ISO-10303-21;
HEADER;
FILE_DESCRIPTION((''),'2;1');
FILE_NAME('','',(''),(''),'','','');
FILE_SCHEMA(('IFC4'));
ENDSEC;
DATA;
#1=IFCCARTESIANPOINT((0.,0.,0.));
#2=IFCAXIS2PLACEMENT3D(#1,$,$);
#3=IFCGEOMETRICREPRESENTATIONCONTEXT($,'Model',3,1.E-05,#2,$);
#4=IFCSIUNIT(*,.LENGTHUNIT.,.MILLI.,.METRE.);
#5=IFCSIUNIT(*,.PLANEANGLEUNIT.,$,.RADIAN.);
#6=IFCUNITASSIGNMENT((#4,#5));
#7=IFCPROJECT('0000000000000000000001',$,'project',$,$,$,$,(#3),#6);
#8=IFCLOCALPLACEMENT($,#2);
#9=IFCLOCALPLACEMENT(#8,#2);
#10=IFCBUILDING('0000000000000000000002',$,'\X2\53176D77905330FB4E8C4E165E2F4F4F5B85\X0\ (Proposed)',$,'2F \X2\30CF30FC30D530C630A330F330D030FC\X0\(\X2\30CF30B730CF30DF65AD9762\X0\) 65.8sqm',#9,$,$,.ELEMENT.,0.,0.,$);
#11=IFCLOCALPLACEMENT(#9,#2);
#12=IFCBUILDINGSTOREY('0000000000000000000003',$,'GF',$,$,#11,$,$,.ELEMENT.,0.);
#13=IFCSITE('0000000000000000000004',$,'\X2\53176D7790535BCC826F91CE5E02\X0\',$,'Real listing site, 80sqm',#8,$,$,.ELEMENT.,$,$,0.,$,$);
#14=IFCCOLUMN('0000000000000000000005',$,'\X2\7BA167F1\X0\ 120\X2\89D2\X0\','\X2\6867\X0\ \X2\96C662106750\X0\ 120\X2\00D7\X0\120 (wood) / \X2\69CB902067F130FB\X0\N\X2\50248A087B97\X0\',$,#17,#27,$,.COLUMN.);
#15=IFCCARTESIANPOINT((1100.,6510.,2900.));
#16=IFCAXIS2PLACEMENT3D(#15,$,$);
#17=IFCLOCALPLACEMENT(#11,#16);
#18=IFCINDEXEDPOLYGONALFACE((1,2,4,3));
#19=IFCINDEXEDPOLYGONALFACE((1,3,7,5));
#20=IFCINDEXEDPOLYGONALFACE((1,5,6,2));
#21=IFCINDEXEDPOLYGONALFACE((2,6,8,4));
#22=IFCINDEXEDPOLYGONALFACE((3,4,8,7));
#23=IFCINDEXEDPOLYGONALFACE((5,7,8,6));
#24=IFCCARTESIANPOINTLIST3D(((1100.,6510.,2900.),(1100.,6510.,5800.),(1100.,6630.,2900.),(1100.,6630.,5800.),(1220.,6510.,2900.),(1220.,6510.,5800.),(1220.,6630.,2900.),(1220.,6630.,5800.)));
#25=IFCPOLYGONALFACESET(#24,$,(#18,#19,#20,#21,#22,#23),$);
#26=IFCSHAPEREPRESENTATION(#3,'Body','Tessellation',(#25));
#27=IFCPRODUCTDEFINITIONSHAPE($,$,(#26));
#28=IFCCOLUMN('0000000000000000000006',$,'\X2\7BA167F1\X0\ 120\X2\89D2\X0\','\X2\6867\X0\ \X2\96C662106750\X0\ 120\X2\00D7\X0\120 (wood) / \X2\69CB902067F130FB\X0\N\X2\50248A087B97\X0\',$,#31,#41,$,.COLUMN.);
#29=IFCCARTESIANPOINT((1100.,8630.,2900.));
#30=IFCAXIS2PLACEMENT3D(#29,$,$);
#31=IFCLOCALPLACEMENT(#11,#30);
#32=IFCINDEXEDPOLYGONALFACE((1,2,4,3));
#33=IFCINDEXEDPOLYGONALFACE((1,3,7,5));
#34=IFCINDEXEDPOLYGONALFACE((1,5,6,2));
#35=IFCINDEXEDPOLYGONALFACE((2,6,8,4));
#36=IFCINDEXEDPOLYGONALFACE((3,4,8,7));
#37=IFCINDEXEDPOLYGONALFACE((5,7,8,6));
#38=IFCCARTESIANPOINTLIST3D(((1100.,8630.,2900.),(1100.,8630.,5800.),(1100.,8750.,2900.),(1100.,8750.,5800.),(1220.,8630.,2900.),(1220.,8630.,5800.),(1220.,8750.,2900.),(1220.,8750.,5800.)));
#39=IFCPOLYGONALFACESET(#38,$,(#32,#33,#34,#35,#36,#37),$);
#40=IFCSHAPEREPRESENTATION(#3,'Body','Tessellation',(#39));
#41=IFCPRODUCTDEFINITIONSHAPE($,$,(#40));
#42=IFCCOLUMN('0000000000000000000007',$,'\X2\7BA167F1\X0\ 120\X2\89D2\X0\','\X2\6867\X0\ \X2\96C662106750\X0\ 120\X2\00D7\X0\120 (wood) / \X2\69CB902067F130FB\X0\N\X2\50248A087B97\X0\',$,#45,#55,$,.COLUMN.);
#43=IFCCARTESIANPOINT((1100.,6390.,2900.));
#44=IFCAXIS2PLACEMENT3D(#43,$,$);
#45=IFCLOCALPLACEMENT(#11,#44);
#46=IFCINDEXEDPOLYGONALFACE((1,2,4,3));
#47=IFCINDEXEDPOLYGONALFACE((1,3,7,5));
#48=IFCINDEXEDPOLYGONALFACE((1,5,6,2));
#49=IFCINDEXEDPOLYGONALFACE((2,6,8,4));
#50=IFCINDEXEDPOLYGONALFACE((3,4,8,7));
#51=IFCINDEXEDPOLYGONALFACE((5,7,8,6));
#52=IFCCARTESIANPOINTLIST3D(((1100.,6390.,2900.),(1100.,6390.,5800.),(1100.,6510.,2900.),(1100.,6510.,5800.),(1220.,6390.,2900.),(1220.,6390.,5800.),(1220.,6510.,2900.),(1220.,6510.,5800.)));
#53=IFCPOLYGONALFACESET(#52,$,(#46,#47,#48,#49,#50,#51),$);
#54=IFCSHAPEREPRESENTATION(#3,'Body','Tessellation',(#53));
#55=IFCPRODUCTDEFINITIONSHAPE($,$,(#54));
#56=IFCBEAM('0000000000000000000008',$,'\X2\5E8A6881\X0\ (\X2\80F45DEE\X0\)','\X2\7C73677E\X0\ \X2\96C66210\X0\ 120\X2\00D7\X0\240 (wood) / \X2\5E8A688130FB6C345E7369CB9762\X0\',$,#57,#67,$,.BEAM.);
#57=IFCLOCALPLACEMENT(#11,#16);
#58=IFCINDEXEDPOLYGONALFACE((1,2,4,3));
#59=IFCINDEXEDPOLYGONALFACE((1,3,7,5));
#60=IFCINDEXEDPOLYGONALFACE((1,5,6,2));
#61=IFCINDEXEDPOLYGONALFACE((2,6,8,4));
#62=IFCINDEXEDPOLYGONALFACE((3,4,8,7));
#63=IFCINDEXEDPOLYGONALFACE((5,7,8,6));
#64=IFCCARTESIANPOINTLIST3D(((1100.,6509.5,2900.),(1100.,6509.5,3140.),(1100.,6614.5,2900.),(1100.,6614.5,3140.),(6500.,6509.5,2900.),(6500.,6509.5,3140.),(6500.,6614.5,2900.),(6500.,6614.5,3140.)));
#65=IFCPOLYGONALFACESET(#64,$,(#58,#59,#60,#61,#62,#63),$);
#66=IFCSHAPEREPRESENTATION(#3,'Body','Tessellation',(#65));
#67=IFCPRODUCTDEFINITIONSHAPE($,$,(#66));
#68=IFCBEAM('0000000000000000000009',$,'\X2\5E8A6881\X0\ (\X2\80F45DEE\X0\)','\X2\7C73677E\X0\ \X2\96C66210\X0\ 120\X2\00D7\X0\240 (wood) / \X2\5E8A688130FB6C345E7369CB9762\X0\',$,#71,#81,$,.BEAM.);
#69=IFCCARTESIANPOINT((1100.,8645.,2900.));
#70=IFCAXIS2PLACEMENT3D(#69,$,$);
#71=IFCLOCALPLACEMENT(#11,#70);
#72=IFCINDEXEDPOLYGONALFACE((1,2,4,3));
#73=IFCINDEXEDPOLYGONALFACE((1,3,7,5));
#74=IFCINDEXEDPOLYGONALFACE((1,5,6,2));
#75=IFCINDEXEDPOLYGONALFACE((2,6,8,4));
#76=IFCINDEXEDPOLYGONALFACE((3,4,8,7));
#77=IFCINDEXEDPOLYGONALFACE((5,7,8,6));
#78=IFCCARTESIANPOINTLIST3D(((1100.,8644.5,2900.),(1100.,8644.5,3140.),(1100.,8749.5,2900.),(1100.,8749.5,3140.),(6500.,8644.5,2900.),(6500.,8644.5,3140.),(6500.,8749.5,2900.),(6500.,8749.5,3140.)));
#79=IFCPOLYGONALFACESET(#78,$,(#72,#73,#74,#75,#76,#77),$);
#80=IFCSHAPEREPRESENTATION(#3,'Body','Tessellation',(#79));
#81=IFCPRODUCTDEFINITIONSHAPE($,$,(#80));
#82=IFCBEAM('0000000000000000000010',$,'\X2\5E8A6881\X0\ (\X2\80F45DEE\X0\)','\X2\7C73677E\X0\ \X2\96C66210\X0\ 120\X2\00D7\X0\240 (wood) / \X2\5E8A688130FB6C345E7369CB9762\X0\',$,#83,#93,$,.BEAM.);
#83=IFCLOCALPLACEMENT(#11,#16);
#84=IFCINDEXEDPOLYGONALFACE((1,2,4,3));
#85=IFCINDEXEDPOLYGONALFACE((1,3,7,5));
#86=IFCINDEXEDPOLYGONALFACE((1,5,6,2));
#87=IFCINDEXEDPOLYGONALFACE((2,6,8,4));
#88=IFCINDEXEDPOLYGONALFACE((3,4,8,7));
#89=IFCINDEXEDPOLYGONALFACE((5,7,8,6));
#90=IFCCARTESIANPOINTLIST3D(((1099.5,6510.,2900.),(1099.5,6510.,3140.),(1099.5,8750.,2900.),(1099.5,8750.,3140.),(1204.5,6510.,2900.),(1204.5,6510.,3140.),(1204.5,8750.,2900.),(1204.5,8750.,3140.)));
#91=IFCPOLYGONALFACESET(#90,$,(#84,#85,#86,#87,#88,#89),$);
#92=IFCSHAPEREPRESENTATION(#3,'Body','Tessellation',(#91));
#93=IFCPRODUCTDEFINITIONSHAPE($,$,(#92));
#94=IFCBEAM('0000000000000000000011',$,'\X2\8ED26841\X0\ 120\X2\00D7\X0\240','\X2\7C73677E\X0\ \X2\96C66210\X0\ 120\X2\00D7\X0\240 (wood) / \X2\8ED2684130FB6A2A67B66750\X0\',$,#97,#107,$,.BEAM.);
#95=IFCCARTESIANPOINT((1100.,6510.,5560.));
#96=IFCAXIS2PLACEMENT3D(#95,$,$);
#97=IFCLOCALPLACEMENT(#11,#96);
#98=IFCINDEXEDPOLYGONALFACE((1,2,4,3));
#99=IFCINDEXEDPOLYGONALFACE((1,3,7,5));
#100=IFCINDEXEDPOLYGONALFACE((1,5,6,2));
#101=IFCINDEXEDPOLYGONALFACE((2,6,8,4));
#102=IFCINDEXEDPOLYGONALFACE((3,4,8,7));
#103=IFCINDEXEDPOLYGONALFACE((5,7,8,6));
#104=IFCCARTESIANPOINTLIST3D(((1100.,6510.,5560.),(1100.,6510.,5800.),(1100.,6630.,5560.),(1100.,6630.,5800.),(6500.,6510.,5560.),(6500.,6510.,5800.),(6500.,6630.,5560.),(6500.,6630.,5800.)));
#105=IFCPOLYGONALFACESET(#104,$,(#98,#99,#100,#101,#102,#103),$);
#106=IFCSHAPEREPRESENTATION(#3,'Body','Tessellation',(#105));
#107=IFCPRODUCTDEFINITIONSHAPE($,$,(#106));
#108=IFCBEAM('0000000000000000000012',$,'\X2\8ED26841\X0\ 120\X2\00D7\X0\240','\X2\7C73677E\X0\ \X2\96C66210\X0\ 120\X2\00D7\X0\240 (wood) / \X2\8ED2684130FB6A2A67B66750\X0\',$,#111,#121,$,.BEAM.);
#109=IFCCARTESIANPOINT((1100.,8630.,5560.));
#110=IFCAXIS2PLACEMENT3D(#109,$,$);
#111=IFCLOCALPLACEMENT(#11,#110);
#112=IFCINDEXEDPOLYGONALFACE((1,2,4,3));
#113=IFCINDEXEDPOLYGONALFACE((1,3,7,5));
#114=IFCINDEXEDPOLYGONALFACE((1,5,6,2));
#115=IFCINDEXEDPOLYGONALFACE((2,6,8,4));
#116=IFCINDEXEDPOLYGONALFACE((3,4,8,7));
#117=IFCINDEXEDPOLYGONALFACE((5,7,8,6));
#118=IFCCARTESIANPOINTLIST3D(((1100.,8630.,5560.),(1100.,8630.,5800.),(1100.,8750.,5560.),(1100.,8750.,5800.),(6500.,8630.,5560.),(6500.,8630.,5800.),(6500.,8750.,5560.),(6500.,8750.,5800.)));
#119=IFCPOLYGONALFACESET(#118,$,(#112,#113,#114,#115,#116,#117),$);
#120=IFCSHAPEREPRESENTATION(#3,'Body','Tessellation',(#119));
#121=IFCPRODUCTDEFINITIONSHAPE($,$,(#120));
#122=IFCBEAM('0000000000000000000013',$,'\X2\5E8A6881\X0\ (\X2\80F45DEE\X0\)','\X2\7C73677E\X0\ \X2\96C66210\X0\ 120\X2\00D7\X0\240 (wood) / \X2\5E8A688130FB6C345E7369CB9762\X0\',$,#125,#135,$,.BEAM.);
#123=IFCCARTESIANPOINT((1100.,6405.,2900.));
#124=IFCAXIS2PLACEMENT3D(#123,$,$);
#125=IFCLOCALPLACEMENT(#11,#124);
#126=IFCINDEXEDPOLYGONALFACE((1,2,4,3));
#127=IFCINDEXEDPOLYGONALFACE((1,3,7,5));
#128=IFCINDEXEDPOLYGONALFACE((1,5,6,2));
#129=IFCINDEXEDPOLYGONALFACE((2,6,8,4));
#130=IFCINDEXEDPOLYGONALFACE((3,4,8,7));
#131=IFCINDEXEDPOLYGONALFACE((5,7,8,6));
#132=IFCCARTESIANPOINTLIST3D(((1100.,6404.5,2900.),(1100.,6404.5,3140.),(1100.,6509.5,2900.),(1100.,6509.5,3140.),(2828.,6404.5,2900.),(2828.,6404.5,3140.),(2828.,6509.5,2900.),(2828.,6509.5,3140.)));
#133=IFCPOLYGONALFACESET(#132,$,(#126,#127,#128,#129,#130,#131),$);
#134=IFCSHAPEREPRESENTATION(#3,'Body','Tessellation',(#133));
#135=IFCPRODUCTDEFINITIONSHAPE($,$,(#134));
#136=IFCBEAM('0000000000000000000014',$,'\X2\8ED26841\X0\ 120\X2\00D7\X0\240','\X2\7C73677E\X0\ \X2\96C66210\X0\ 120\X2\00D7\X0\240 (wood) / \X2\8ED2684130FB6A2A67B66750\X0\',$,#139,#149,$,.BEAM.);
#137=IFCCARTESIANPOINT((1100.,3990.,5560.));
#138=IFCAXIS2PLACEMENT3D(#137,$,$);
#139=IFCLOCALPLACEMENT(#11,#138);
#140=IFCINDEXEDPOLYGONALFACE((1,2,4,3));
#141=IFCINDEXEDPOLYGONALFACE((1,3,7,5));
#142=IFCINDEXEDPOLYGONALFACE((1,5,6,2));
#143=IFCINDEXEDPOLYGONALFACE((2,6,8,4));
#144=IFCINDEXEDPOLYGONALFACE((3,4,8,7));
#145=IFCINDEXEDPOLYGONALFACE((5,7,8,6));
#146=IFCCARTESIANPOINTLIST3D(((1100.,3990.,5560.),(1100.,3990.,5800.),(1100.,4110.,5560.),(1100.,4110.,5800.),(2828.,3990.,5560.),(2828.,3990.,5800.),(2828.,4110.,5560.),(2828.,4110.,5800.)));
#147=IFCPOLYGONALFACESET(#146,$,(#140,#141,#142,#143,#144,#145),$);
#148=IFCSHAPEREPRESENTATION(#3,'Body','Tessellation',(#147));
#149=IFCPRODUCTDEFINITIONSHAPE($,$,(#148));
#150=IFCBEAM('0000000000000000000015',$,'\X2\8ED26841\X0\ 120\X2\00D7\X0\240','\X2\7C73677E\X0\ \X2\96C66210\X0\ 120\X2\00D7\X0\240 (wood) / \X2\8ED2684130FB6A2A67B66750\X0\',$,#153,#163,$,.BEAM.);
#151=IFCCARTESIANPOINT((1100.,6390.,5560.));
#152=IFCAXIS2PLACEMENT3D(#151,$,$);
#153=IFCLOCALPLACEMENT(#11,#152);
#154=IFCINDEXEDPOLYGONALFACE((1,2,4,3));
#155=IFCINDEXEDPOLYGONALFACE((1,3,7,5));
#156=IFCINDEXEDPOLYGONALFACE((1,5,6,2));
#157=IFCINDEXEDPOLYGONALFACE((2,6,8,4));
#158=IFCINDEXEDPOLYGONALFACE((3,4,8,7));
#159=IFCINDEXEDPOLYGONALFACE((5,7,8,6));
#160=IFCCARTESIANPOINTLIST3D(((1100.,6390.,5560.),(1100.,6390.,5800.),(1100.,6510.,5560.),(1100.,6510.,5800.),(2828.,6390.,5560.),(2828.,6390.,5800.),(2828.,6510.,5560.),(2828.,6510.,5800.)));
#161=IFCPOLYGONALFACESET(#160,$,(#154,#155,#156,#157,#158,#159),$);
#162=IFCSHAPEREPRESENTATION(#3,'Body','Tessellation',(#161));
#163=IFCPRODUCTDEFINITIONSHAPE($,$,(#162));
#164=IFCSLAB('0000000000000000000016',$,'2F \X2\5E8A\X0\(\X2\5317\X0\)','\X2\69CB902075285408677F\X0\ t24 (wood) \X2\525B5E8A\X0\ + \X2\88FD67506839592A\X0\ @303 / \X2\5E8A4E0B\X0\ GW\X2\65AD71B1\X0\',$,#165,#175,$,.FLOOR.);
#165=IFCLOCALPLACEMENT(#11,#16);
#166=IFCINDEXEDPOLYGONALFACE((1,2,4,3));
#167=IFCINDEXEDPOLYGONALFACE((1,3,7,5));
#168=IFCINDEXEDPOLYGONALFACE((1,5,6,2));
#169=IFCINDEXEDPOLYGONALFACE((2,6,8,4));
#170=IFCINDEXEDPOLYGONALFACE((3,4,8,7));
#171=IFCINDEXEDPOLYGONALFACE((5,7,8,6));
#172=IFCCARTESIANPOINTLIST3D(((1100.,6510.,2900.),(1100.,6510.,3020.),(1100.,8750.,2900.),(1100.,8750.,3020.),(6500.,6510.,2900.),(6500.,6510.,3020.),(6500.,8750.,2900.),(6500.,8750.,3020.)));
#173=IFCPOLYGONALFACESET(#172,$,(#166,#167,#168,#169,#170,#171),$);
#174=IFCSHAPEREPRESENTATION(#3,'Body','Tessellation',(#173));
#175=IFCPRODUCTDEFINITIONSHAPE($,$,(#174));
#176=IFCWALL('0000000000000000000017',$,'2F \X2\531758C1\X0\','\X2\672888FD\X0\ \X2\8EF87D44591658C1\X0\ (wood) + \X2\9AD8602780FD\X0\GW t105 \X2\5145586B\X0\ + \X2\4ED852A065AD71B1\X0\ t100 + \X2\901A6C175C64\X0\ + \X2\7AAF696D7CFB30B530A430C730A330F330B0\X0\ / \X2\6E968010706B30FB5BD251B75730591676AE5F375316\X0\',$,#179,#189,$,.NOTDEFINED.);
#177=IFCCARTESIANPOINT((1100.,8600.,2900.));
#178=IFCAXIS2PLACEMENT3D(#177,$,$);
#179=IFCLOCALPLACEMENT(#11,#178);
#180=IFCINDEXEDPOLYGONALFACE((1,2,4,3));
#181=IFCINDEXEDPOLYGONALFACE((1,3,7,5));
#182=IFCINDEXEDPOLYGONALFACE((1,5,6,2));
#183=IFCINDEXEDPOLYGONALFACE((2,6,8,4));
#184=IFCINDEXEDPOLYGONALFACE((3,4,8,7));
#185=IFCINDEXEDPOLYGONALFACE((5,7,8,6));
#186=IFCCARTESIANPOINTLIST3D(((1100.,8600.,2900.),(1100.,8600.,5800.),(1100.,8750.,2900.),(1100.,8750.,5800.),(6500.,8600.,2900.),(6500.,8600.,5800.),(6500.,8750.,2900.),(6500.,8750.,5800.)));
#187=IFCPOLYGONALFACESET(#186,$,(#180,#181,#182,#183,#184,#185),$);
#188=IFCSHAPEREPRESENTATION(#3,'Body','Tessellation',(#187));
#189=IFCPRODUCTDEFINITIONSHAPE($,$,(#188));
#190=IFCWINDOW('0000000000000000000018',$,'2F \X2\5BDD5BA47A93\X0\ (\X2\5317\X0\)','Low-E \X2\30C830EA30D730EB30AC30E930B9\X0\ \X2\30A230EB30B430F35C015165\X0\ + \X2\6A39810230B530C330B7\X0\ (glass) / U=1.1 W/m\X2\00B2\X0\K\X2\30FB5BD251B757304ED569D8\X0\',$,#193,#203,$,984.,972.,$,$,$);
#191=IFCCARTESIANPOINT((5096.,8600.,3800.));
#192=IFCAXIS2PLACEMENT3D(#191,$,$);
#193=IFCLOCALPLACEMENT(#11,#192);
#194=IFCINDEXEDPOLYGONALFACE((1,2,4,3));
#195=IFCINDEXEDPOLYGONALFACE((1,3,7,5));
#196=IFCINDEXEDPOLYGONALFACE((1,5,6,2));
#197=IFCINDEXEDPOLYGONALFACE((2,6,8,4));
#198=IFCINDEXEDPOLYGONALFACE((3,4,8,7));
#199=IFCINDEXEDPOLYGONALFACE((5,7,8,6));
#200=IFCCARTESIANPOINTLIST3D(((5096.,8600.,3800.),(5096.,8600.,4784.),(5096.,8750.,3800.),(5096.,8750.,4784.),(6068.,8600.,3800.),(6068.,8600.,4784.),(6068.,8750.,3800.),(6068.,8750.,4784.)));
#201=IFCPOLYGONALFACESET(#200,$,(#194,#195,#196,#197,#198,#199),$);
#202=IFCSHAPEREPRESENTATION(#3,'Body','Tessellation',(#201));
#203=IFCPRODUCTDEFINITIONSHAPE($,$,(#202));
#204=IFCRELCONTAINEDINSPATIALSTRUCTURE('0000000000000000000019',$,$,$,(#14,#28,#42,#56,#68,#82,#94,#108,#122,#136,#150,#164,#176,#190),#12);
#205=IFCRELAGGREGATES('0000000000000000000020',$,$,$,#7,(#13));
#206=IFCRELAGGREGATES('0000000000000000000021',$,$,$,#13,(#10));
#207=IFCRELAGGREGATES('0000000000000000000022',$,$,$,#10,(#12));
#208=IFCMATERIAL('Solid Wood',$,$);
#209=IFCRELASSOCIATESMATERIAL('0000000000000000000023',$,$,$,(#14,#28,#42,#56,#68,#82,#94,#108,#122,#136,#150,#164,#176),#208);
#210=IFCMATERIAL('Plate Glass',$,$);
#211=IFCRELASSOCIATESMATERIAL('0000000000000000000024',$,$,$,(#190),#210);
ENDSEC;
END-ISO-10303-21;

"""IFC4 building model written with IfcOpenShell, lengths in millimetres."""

from ifc_helpers import new_model, si_unit, frame, frame_2d, origin, place, context, project, spatial, rectangle, extrude, material, element, fill, save


model = new_model("IFC4")

# Units and contexts
model_context = context("Model", 3, precision=1e-05, world=origin())
ifc_project = project(units=[si_unit("LENGTHUNIT", "METRE", prefix="MILLI"), si_unit("PLANEANGLEUNIT", "RADIAN")], contexts=[model_context])

# Site, building, storey
site_placement = place(None, origin())
site = spatial("IfcSite", under=ifc_project, at=site_placement, Name="北海道富良野市", ObjectType="Real listing site, 80sqm", CompositionType="ELEMENT", RefElevation=0.0)
building_placement = place(site_placement, origin())
building = spatial("IfcBuilding", under=site, at=building_placement, Name="北海道・二世帯住宅 (Proposed)", ObjectType="2F ハーフティンバー(ハシハミ断面) 65.8sqm", CompositionType="ELEMENT", ElevationOfRefHeight=0.0, ElevationOfTerrain=0.0)
storey_placement = place(building_placement, origin())
storey = spatial("IfcBuildingStorey", under=building, at=storey_placement, Name="GF", CompositionType="ELEMENT", Elevation=0.0)

# Columns
ifc_material_1 = material(Name="Solid Wood")
column_1_placement = place(storey_placement, frame((1100.0, 6510.0, 2900.0)))
element("IfcColumn", 1, at=column_1_placement, inside=storey, material=ifc_material_1, Name="管柱 120角", Description="桧 集成材 120×120 (wood) / 構造柱・N値計算", PredefinedType="COLUMN", context=model_context, shape_type="SweptSolid", body=[
    extrude(rectangle(XDim=120.0, YDim=120.0, at=frame_2d((60.0, 60.0))), frame((1100.0, 6510.0, 2900.0)), (0.0, 0.0, 1.0), 2900.0),
])
column_2_placement = place(storey_placement, frame((1100.0, 8630.0, 2900.0)))
element("IfcColumn", 2, at=column_2_placement, inside=storey, material=ifc_material_1, Name="管柱 120角", Description="桧 集成材 120×120 (wood) / 構造柱・N値計算", PredefinedType="COLUMN", context=model_context, shape_type="SweptSolid", body=[
    extrude(rectangle(XDim=120.0, YDim=120.0, at=frame_2d((60.0, 60.0))), frame((1100.0, 8630.0, 2900.0)), (0.0, 0.0, 1.0), 2900.0),
])
column_3_placement = place(storey_placement, frame((1100.0, 6390.0, 2900.0)))
element("IfcColumn", 3, at=column_3_placement, inside=storey, material=ifc_material_1, Name="管柱 120角", Description="桧 集成材 120×120 (wood) / 構造柱・N値計算", PredefinedType="COLUMN", context=model_context, shape_type="SweptSolid", body=[
    extrude(rectangle(XDim=120.0, YDim=120.0, at=frame_2d((60.0, 60.0))), frame((1100.0, 6390.0, 2900.0)), (0.0, 0.0, 1.0), 2900.0),
])

# Beams
beam_1_placement = place(storey_placement, frame((1100.0, 6510.0, 2900.0)))
element("IfcBeam", 4, at=beam_1_placement, inside=storey, material=ifc_material_1, Name="床梁 (胴差)", Description="米松 集成 120×240 (wood) / 床梁・水平構面", PredefinedType="BEAM", context=model_context, shape_type="SweptSolid", body=[
    extrude(rectangle(XDim=5400.0, YDim=105.0, at=frame_2d((2700.0, 52.0))), frame((1100.0, 6510.0, 2900.0)), (0.0, 0.0, 1.0), 240.0),
])
beam_2_placement = place(storey_placement, frame((1100.0, 8645.0, 2900.0)))
element("IfcBeam", 5, at=beam_2_placement, inside=storey, material=ifc_material_1, Name="床梁 (胴差)", Description="米松 集成 120×240 (wood) / 床梁・水平構面", PredefinedType="BEAM", context=model_context, shape_type="SweptSolid", body=[
    extrude(rectangle(XDim=5400.0, YDim=105.0, at=frame_2d((2700.0, 52.0))), frame((1100.0, 8645.0, 2900.0)), (0.0, 0.0, 1.0), 240.0),
])
beam_3_placement = place(storey_placement, frame((1100.0, 6510.0, 2900.0)))
element("IfcBeam", 6, at=beam_3_placement, inside=storey, material=ifc_material_1, Name="床梁 (胴差)", Description="米松 集成 120×240 (wood) / 床梁・水平構面", PredefinedType="BEAM", context=model_context, shape_type="SweptSolid", body=[
    extrude(rectangle(XDim=105.0, YDim=2240.0, at=frame_2d((52.0, 1120.0))), frame((1100.0, 6510.0, 2900.0)), (0.0, 0.0, 1.0), 240.0),
])
beam_4_placement = place(storey_placement, frame((1100.0, 6510.0, 5560.0)))
element("IfcBeam", 7, at=beam_4_placement, inside=storey, material=ifc_material_1, Name="軒桁 120×240", Description="米松 集成 120×240 (wood) / 軒桁・横架材", PredefinedType="BEAM", context=model_context, shape_type="SweptSolid", body=[
    extrude(rectangle(XDim=5400.0, YDim=120.0, at=frame_2d((2700.0, 60.0))), frame((1100.0, 6510.0, 5560.0)), (0.0, 0.0, 1.0), 240.0),
])
beam_5_placement = place(storey_placement, frame((1100.0, 8630.0, 5560.0)))
element("IfcBeam", 8, at=beam_5_placement, inside=storey, material=ifc_material_1, Name="軒桁 120×240", Description="米松 集成 120×240 (wood) / 軒桁・横架材", PredefinedType="BEAM", context=model_context, shape_type="SweptSolid", body=[
    extrude(rectangle(XDim=5400.0, YDim=120.0, at=frame_2d((2700.0, 60.0))), frame((1100.0, 8630.0, 5560.0)), (0.0, 0.0, 1.0), 240.0),
])
beam_6_placement = place(storey_placement, frame((1100.0, 6405.0, 2900.0)))
element("IfcBeam", 9, at=beam_6_placement, inside=storey, material=ifc_material_1, Name="床梁 (胴差)", Description="米松 集成 120×240 (wood) / 床梁・水平構面", PredefinedType="BEAM", context=model_context, shape_type="SweptSolid", body=[
    extrude(rectangle(XDim=1728.0, YDim=105.0, at=frame_2d((864.0, 52.0))), frame((1100.0, 6405.0, 2900.0)), (0.0, 0.0, 1.0), 240.0),
])
beam_7_placement = place(storey_placement, frame((1100.0, 3990.0, 5560.0)))
element("IfcBeam", 10, at=beam_7_placement, inside=storey, material=ifc_material_1, Name="軒桁 120×240", Description="米松 集成 120×240 (wood) / 軒桁・横架材", PredefinedType="BEAM", context=model_context, shape_type="SweptSolid", body=[
    extrude(rectangle(XDim=1728.0, YDim=120.0, at=frame_2d((864.0, 60.0))), frame((1100.0, 3990.0, 5560.0)), (0.0, 0.0, 1.0), 240.0),
])
beam_8_placement = place(storey_placement, frame((1100.0, 6390.0, 5560.0)))
element("IfcBeam", 11, at=beam_8_placement, inside=storey, material=ifc_material_1, Name="軒桁 120×240", Description="米松 集成 120×240 (wood) / 軒桁・横架材", PredefinedType="BEAM", context=model_context, shape_type="SweptSolid", body=[
    extrude(rectangle(XDim=1728.0, YDim=120.0, at=frame_2d((864.0, 60.0))), frame((1100.0, 6390.0, 5560.0)), (0.0, 0.0, 1.0), 240.0),
])

# Slab
slab_placement = place(storey_placement, frame((1100.0, 6510.0, 2900.0)))
element("IfcSlab", 12, at=slab_placement, inside=storey, material=ifc_material_1, Name="2F 床(北)", Description="構造用合板 t24 (wood) 剛床 + 製材根太 @303 / 床下 GW断熱", PredefinedType="FLOOR", context=model_context, shape_type="SweptSolid", body=[
    extrude(rectangle(XDim=5400.0, YDim=2240.0, at=frame_2d((2700.0, 1120.0))), frame((1100.0, 6510.0, 2900.0)), (0.0, 0.0, 1.0), 120.0),
])

# Wall, opening, window
wall_placement = place(storey_placement, frame((1100.0, 8600.0, 2900.0)))
wall = element("IfcWall", 13, at=wall_placement, inside=storey, material=ifc_material_1, Name="2F 北壁", Description="木製 軸組外壁 (wood) + 高性能GW t105 充填 + 付加断熱 t100 + 通気層 + 窯業系サイディング / 準耐火・寒冷地外皮強化", PredefinedType="NOTDEFINED", context=model_context, shape_type="SweptSolid", body=[
    extrude(rectangle(XDim=5400.0, YDim=150.0, at=frame_2d((2700.0, 75.0))), frame((1100.0, 8600.0, 2900.0)), (0.0, 0.0, 1.0), 2900.0),
])
opening_placement = place(storey_placement, frame((5096.0, 8600.0, 3800.0)))
opening = element("IfcOpeningElement", 14, at=opening_placement, cuts=wall, PredefinedType="NOTDEFINED", context=model_context, shape_type="SweptSolid", body=[
    extrude(rectangle(XDim=972.0, YDim=150.0, at=frame_2d((486.0, 75.0))), frame((5096.0, 8600.0, 3800.0)), (0.0, 0.0, 1.0), 984.0),
])
ifc_material_2 = material(Name="Plate Glass")
window_placement = place(storey_placement, frame((5096.0, 8600.0, 3800.0)))
window = element("IfcWindow", 15, at=window_placement, inside=storey, material=ifc_material_2, Name="2F 寝室窓 (北)", Description="Low-E トリプルガラス アルゴン封入 + 樹脂サッシ (glass) / U=1.1 W/m²K・寒冷地仕様", OverallHeight=984.0, OverallWidth=972.0, context=model_context, shape_type="SweptSolid", body=[
    extrude(rectangle(XDim=972.0, YDim=150.0, at=frame_2d((486.0, 75.0))), frame((5096.0, 8600.0, 3800.0)), (0.0, 0.0, 1.0), 984.0),
])
fill(opening, window)

save(model, "model.ifc")
